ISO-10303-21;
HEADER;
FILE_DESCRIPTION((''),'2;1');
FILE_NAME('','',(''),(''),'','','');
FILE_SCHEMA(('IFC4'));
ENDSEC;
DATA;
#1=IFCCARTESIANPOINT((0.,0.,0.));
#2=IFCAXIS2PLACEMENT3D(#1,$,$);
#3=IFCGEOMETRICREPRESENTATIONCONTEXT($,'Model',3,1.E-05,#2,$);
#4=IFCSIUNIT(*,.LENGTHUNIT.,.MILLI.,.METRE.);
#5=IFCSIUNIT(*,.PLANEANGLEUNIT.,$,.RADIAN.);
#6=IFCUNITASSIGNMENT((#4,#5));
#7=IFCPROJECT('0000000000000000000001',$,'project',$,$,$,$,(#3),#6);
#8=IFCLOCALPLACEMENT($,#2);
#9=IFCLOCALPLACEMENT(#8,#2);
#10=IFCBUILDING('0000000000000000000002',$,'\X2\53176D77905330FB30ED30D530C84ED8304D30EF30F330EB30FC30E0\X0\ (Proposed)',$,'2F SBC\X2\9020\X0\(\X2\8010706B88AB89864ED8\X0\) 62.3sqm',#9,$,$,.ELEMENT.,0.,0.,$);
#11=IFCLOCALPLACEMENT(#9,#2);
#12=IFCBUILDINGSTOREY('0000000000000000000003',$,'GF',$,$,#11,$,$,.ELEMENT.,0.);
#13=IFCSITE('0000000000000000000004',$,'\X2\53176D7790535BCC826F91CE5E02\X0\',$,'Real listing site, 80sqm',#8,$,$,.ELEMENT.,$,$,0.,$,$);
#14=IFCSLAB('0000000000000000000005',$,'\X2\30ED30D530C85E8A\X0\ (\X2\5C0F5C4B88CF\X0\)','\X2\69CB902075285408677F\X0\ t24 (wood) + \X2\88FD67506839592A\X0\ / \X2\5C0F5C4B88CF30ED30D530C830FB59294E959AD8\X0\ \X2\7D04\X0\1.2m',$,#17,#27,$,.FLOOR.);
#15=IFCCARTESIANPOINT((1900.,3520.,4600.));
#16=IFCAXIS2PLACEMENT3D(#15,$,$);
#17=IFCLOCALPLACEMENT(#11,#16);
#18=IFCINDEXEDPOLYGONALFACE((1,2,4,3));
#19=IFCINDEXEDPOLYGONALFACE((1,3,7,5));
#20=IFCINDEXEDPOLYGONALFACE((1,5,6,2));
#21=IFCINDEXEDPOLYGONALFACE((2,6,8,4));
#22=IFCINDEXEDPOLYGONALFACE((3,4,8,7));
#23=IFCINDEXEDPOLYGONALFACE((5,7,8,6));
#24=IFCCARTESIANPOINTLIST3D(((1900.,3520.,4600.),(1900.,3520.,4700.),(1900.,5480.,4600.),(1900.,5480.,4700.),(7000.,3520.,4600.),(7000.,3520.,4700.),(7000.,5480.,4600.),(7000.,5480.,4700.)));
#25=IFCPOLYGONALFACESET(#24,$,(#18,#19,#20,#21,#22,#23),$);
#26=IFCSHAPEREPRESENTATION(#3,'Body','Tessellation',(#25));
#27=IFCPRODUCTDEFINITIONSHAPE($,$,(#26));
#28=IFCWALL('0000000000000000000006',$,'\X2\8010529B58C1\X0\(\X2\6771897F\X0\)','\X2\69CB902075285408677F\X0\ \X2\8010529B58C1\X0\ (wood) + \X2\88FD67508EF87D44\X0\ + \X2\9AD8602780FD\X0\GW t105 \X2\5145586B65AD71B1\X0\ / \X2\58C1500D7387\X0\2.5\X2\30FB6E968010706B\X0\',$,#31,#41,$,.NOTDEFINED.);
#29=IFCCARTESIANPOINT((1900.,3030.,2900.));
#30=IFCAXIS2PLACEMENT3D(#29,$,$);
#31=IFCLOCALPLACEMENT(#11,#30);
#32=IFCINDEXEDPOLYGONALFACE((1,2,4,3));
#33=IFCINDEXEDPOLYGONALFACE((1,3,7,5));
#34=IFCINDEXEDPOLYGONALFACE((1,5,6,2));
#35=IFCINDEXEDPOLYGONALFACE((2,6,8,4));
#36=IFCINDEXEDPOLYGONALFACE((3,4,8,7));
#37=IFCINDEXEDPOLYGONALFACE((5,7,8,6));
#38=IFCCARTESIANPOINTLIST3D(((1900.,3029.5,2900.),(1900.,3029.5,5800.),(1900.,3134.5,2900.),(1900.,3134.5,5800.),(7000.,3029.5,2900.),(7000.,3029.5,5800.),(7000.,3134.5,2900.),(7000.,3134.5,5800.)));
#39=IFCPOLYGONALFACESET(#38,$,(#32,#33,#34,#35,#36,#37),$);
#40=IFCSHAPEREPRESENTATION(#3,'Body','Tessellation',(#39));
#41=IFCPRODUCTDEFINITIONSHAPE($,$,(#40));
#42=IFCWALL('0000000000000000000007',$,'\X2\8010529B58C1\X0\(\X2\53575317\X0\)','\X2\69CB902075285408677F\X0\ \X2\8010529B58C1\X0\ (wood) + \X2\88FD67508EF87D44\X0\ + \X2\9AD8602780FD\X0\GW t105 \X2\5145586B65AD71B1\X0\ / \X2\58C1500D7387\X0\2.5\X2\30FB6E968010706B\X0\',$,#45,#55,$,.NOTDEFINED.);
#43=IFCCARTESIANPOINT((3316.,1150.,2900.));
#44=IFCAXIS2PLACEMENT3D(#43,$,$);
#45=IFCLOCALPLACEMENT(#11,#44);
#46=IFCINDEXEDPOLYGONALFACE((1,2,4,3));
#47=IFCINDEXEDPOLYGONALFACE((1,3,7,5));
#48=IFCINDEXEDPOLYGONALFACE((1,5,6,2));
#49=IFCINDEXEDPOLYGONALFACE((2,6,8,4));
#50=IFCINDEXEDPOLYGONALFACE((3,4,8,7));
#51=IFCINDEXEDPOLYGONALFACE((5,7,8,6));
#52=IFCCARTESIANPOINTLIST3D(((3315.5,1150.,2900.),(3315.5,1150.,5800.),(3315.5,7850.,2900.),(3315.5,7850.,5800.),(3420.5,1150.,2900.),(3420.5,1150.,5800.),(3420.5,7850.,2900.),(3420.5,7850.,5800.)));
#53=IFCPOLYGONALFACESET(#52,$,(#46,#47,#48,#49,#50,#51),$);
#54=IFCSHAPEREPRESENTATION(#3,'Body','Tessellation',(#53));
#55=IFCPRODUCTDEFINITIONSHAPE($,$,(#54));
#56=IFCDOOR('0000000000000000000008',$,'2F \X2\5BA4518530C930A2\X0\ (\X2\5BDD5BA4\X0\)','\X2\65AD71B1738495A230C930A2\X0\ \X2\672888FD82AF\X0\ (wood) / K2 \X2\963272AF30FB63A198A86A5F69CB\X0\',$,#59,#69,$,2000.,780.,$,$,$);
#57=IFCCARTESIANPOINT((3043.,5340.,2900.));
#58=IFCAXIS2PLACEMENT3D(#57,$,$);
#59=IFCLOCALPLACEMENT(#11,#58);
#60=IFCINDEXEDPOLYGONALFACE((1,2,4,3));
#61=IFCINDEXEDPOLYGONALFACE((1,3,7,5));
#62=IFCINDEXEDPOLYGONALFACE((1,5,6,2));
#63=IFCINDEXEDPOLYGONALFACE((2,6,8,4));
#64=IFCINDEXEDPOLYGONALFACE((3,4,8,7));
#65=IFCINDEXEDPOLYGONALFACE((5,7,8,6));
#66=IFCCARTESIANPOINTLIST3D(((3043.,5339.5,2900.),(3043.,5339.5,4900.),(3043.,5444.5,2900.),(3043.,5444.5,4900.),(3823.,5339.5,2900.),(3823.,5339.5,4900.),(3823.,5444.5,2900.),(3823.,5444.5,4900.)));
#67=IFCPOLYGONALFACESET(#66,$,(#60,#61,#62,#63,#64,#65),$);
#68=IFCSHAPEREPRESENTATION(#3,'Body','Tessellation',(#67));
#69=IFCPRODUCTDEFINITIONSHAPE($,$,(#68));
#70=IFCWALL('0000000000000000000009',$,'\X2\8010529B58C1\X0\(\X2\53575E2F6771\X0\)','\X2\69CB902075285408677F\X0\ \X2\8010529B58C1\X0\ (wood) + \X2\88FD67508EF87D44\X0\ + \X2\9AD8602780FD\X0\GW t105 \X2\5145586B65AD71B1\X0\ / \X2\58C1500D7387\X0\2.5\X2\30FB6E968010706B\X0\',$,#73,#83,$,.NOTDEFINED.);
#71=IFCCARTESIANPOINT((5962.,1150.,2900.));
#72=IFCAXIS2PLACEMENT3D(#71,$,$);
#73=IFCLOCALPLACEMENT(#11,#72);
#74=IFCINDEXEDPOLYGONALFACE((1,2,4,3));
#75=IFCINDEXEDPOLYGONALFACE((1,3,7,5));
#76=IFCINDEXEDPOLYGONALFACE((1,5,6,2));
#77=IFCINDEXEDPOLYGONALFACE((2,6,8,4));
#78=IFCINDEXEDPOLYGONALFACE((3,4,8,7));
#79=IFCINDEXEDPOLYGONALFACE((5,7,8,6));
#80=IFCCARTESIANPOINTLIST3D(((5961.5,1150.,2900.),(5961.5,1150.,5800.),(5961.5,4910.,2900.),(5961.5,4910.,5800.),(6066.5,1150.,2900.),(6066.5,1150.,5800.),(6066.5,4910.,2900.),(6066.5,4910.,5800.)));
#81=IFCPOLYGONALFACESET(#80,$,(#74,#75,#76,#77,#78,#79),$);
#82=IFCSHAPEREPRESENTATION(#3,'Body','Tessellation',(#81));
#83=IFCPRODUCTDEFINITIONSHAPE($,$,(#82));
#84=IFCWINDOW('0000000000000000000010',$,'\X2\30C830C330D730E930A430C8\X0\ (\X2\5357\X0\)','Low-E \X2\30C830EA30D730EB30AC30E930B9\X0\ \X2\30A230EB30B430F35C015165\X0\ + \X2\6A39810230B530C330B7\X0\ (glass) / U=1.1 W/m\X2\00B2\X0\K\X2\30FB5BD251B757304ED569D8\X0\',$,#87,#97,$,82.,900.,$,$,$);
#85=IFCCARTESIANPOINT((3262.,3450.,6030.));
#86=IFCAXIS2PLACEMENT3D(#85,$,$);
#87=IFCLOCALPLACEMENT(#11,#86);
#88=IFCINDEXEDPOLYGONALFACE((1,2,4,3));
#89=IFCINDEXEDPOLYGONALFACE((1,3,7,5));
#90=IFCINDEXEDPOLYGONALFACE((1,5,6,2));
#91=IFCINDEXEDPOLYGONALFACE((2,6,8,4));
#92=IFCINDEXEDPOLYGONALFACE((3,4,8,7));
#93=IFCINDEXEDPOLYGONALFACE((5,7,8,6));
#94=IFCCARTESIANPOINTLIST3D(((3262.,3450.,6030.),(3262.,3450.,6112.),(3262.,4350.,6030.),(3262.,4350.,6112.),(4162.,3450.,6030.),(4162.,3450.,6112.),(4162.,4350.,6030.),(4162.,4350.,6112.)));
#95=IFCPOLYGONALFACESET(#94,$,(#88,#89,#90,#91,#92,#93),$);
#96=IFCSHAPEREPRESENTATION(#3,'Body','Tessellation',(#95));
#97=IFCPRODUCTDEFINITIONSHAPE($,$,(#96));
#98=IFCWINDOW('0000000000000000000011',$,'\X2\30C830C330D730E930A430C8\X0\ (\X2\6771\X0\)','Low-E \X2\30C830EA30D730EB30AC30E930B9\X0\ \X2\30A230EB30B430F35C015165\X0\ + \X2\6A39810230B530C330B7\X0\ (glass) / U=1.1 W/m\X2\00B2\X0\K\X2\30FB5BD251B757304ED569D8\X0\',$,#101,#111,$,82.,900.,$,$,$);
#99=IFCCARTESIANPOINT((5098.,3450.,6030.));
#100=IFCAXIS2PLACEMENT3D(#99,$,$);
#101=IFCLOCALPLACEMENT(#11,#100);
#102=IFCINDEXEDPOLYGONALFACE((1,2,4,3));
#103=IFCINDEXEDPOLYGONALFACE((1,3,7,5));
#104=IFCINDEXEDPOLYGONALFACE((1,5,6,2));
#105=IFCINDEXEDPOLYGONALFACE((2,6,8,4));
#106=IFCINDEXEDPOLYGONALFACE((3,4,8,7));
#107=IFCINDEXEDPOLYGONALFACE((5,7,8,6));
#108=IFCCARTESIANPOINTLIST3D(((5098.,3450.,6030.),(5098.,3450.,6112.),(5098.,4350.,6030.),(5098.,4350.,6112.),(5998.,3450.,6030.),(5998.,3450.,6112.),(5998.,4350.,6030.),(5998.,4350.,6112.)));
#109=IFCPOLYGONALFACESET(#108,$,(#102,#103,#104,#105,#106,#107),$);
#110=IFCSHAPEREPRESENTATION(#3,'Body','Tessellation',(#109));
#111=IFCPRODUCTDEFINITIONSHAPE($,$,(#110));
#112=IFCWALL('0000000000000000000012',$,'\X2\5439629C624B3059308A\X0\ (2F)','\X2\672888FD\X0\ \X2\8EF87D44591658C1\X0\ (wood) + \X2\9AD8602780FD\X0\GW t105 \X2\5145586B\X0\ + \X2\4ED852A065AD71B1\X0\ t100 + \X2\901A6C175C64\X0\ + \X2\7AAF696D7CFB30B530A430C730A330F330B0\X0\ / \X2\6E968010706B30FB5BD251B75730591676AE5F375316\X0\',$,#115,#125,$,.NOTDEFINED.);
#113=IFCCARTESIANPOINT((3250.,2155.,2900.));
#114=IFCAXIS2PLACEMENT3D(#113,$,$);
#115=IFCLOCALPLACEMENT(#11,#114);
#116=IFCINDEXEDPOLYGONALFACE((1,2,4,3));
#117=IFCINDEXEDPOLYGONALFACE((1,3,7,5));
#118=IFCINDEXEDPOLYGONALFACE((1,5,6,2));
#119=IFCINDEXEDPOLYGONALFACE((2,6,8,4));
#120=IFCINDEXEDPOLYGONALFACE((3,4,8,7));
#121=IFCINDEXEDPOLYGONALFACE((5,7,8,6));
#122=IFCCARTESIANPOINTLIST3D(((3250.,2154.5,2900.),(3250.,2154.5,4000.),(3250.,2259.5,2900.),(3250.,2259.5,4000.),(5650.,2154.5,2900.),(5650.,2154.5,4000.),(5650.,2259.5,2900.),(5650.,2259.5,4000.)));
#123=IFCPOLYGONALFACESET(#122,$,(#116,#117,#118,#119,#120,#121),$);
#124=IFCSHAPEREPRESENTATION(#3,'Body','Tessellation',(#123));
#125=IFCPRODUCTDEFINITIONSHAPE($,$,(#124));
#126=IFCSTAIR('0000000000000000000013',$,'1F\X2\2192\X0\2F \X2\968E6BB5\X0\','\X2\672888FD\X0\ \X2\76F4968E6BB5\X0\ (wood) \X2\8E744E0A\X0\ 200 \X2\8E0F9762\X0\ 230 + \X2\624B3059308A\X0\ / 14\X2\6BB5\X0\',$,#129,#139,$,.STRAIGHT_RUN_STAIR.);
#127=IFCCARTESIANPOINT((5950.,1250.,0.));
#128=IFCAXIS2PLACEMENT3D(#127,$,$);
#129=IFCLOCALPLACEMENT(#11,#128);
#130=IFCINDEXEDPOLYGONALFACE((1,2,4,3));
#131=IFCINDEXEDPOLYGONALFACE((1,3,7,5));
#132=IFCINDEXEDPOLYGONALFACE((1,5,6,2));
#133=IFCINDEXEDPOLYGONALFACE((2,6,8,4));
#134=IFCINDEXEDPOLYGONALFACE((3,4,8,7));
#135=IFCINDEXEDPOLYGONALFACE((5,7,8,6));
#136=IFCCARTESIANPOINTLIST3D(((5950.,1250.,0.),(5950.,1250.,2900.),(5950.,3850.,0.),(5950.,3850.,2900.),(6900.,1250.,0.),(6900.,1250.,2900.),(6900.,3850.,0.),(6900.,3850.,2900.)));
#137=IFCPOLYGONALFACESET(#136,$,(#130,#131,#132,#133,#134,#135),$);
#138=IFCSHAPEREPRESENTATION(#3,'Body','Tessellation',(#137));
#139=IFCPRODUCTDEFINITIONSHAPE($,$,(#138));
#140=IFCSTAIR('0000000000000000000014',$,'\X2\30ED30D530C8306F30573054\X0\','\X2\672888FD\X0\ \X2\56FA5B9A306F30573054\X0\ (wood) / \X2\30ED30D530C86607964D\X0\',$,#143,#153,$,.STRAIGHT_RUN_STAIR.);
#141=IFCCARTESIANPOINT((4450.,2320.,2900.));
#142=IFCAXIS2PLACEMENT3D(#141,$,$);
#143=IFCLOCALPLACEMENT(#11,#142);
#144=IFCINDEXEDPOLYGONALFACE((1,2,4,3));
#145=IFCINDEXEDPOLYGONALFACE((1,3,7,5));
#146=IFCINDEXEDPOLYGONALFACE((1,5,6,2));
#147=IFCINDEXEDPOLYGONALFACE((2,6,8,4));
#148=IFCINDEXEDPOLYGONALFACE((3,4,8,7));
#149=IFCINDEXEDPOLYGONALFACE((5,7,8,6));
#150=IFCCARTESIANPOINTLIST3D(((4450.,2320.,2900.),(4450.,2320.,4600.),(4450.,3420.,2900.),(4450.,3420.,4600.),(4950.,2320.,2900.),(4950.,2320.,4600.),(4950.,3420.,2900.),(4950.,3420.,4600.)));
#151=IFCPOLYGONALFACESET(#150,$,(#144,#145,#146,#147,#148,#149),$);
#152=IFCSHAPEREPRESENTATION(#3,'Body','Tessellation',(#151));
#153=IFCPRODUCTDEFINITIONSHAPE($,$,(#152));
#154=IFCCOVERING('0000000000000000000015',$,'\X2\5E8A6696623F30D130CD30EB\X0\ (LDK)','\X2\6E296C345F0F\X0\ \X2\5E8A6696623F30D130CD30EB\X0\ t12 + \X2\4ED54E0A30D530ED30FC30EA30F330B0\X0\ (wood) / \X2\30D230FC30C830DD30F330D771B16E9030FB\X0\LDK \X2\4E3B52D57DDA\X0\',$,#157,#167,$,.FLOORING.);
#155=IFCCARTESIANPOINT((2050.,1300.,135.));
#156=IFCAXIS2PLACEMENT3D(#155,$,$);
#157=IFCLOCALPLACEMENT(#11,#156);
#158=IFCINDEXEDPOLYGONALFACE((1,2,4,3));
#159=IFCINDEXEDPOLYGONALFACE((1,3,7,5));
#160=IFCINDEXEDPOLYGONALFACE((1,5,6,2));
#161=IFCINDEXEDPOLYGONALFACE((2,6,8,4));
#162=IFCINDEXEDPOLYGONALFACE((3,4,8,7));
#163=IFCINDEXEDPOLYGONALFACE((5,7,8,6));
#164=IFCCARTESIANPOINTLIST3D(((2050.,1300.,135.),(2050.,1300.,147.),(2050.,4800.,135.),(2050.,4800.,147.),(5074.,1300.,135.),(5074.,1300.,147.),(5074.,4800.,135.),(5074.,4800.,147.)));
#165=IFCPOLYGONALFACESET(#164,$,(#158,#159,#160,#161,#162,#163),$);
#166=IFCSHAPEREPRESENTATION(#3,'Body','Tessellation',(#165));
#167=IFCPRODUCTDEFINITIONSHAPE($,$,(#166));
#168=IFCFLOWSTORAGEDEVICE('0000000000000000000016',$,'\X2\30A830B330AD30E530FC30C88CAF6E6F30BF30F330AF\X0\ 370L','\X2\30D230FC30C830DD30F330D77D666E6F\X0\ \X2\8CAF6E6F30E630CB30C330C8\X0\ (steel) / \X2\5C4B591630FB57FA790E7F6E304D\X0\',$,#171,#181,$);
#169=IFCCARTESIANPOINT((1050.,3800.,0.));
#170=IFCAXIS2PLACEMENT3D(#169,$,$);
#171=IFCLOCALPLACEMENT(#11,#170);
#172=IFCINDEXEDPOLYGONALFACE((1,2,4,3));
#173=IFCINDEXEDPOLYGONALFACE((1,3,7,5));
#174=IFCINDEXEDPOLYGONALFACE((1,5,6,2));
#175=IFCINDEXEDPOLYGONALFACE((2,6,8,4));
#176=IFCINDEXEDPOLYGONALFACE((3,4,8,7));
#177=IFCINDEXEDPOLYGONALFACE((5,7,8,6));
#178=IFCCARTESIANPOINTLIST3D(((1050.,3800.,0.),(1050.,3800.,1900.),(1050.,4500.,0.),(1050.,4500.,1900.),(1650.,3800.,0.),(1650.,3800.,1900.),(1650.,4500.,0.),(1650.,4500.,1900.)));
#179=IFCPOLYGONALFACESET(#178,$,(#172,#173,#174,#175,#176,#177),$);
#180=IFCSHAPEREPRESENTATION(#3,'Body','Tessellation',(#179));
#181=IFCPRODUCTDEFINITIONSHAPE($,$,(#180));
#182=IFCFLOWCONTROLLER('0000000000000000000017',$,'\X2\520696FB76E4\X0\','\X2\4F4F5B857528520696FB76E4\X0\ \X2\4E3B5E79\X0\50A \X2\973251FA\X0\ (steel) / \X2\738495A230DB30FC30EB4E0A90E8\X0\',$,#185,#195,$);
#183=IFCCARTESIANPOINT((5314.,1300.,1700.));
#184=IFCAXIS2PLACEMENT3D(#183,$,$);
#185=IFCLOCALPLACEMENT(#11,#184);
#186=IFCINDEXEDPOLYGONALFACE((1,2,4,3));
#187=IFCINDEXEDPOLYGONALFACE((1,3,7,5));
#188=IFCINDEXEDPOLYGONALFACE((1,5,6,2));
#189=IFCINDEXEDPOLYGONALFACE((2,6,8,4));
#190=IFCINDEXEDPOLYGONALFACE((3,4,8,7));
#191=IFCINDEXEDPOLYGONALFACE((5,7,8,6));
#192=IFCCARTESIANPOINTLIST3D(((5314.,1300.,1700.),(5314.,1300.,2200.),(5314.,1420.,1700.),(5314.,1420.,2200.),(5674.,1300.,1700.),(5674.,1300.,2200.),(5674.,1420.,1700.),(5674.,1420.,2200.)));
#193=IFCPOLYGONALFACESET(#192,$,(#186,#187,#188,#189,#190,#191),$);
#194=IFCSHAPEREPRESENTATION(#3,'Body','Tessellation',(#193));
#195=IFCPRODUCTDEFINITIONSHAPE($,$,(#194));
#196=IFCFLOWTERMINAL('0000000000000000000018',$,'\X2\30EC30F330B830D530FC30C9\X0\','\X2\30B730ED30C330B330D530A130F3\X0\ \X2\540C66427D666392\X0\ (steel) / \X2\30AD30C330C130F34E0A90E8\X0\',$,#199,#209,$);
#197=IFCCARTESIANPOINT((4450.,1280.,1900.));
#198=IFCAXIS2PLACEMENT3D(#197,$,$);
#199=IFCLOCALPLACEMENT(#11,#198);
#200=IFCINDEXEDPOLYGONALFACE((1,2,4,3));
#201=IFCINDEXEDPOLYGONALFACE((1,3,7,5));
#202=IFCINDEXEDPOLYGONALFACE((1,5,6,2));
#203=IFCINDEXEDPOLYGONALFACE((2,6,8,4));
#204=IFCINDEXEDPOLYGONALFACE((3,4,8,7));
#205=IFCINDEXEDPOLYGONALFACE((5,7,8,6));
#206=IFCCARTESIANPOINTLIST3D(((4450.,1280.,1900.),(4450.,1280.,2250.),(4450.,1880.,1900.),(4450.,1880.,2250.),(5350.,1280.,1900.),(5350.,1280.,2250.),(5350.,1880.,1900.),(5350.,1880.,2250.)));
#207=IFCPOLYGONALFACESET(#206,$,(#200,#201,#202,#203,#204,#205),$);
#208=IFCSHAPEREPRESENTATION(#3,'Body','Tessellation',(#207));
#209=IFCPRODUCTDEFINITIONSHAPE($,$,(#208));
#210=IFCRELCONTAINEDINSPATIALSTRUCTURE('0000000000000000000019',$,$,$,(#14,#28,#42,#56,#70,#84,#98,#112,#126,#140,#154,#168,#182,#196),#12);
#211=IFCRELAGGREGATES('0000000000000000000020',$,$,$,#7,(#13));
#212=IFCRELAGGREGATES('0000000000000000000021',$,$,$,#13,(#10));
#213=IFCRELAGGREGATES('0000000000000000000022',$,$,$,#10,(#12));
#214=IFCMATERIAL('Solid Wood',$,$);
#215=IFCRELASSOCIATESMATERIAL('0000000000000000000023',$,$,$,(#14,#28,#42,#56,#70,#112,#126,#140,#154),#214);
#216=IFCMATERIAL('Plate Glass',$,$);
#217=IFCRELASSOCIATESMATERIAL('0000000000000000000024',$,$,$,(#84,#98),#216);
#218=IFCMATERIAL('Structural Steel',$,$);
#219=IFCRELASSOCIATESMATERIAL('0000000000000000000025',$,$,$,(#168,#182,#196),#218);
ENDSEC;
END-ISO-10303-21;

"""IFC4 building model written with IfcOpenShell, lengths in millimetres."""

from ifc_helpers import new_model, si_unit, frame, frame_2d, origin, place, context, project, spatial, rectangle, extrude, material, element, fill, save


model = new_model("IFC4")

# Units and contexts
model_context = context("Model", 3, precision=1e-05, world=origin())
ifc_project = project(units=[si_unit("LENGTHUNIT", "METRE", prefix="MILLI"), si_unit("PLANEANGLEUNIT", "RADIAN")], contexts=[model_context])

# Site, building, storey
site_placement = place(None, origin())
site = spatial("IfcSite", under=ifc_project, at=site_placement, Name="北海道富良野市", ObjectType="Real listing site, 80sqm", CompositionType="ELEMENT", RefElevation=0.0)
building_placement = place(site_placement, origin())
building = spatial("IfcBuilding", under=site, at=building_placement, Name="北海道・ロフト付きワンルーム (Proposed)", ObjectType="2F SBC造(耐火被覆付) 62.3sqm", CompositionType="ELEMENT", ElevationOfRefHeight=0.0, ElevationOfTerrain=0.0)
storey_placement = place(building_placement, origin())
storey = spatial("IfcBuildingStorey", under=building, at=storey_placement, Name="GF", CompositionType="ELEMENT", Elevation=0.0)

# Shared definitions
ifc_material_1 = material(Name="Solid Wood")

# Slab
slab_placement = place(storey_placement, frame((1900.0, 3520.0, 4600.0)))
element("IfcSlab", 1, at=slab_placement, inside=storey, material=ifc_material_1, Name="ロフト床 (小屋裏)", Description="構造用合板 t24 (wood) + 製材根太 / 小屋裏ロフト・天井高 約1.2m", PredefinedType="FLOOR", context=model_context, shape_type="SweptSolid", body=[
    extrude(rectangle(XDim=5100.0, YDim=1960.0, at=frame_2d((2550.0, 980.0))), frame((1900.0, 3520.0, 4600.0)), (0.0, 0.0, 1.0), 100.0),
])

# Wall
wall_1_placement = place(storey_placement, frame((1900.0, 3030.0, 2900.0)))
element("IfcWall", 2, at=wall_1_placement, inside=storey, material=ifc_material_1, Name="耐力壁(東西)", Description="構造用合板 耐力壁 (wood) + 製材軸組 + 高性能GW t105 充填断熱 / 壁倍率2.5・準耐火", PredefinedType="NOTDEFINED", context=model_context, shape_type="SweptSolid", body=[
    extrude(rectangle(XDim=5100.0, YDim=105.0, at=frame_2d((2550.0, 52.0))), frame((1900.0, 3030.0, 2900.0)), (0.0, 0.0, 1.0), 2900.0),
])

# Wall, opening, door
wall_2_placement = place(storey_placement, frame((3316.0, 1150.0, 2900.0)))
wall_2 = element("IfcWall", 3, at=wall_2_placement, inside=storey, material=ifc_material_1, Name="耐力壁(南北)", Description="構造用合板 耐力壁 (wood) + 製材軸組 + 高性能GW t105 充填断熱 / 壁倍率2.5・準耐火", PredefinedType="NOTDEFINED", context=model_context, shape_type="SweptSolid", body=[
    extrude(rectangle(XDim=105.0, YDim=6700.0, at=frame_2d((52.0, 3350.0))), frame((3316.0, 1150.0, 2900.0)), (0.0, 0.0, 1.0), 2900.0),
])
opening_placement = place(storey_placement, frame((3043.0, 5340.0, 2900.0)))
opening = element("IfcOpeningElement", 4, at=opening_placement, cuts=wall_2, PredefinedType="NOTDEFINED", context=model_context, shape_type="SweptSolid", body=[
    extrude(rectangle(XDim=780.0, YDim=105.0, at=frame_2d((390.0, 52.0))), frame((3043.0, 5340.0, 2900.0)), (0.0, 0.0, 1.0), 2000.0),
])
door_placement = place(storey_placement, frame((3043.0, 5340.0, 2900.0)))
door = element("IfcDoor", 5, at=door_placement, inside=storey, material=ifc_material_1, Name="2F 室内ドア (寝室)", Description="断熱玄関ドア 木製芯 (wood) / K2 防犯・採風機構", OverallHeight=2000.0, OverallWidth=780.0, context=model_context, shape_type="SweptSolid", body=[
    extrude(rectangle(XDim=780.0, YDim=105.0, at=frame_2d((390.0, 52.0))), frame((3043.0, 5340.0, 2900.0)), (0.0, 0.0, 1.0), 2000.0),
])
fill(opening, door)

# Wall
wall_3_placement = place(storey_placement, frame((5962.0, 1150.0, 2900.0)))
element("IfcWall", 6, at=wall_3_placement, inside=storey, material=ifc_material_1, Name="耐力壁(南帯東)", Description="構造用合板 耐力壁 (wood) + 製材軸組 + 高性能GW t105 充填断熱 / 壁倍率2.5・準耐火", PredefinedType="NOTDEFINED", context=model_context, shape_type="SweptSolid", body=[
    extrude(rectangle(XDim=105.0, YDim=3760.0, at=frame_2d((52.0, 1880.0))), frame((5962.0, 1150.0, 2900.0)), (0.0, 0.0, 1.0), 2900.0),
])

# Windows
ifc_material_2 = material(Name="Plate Glass")
window_1_placement = place(storey_placement, frame((3262.0, 3450.0, 6030.0)))
element("IfcWindow", 7, at=window_1_placement, inside=storey, material=ifc_material_2, Name="トップライト (南)", Description="Low-E トリプルガラス アルゴン封入 + 樹脂サッシ (glass) / U=1.1 W/m²K・寒冷地仕様", OverallHeight=82.0, OverallWidth=900.0, context=model_context, shape_type="SweptSolid", body=[
    extrude(rectangle(XDim=900.0, YDim=900.0, at=frame_2d((450.0, 450.0))), frame((3262.0, 3450.0, 6030.0)), (0.0, 0.0, 1.0), 82.0),
])
window_2_placement = place(storey_placement, frame((5098.0, 3450.0, 6030.0)))
element("IfcWindow", 8, at=window_2_placement, inside=storey, material=ifc_material_2, Name="トップライト (東)", Description="Low-E トリプルガラス アルゴン封入 + 樹脂サッシ (glass) / U=1.1 W/m²K・寒冷地仕様", OverallHeight=82.0, OverallWidth=900.0, context=model_context, shape_type="SweptSolid", body=[
    extrude(rectangle(XDim=900.0, YDim=900.0, at=frame_2d((450.0, 450.0))), frame((5098.0, 3450.0, 6030.0)), (0.0, 0.0, 1.0), 82.0),
])

# Wall
wall_4_placement = place(storey_placement, frame((3250.0, 2155.0, 2900.0)))
element("IfcWall", 9, at=wall_4_placement, inside=storey, material=ifc_material_1, Name="吹抜手すり (2F)", Description="木製 軸組外壁 (wood) + 高性能GW t105 充填 + 付加断熱 t100 + 通気層 + 窯業系サイディング / 準耐火・寒冷地外皮強化", PredefinedType="NOTDEFINED", context=model_context, shape_type="SweptSolid", body=[
    extrude(rectangle(XDim=2400.0, YDim=105.0, at=frame_2d((1200.0, 52.0))), frame((3250.0, 2155.0, 2900.0)), (0.0, 0.0, 1.0), 1100.0),
])

# Stairs
stair_1_placement = place(storey_placement, frame((5950.0, 1250.0, 0.0)))
element("IfcStair", 10, at=stair_1_placement, inside=storey, material=ifc_material_1, Name="1F→2F 階段", Description="木製 直階段 (wood) 蹴上 200 踏面 230 + 手すり / 14段", PredefinedType="STRAIGHT_RUN_STAIR", context=model_context, shape_type="SweptSolid", body=[
    extrude(rectangle(XDim=950.0, YDim=2600.0, at=frame_2d((475.0, 1300.0))), frame((5950.0, 1250.0, 0.0)), (0.0, 0.0, 1.0), 2900.0),
])
stair_2_placement = place(storey_placement, frame((4450.0, 2320.0, 2900.0)))
element("IfcStair", 11, at=stair_2_placement, inside=storey, material=ifc_material_1, Name="ロフトはしご", Description="木製 固定はしご (wood) / ロフト昇降", PredefinedType="STRAIGHT_RUN_STAIR", context=model_context, shape_type="SweptSolid", body=[
    extrude(rectangle(XDim=500.0, YDim=1100.0, at=frame_2d((250.0, 550.0))), frame((4450.0, 2320.0, 2900.0)), (0.0, 0.0, 1.0), 1700.0),
])

# Covering
covering_placement = place(storey_placement, frame((2050.0, 1300.0, 135.0)))
element("IfcCovering", 12, at=covering_placement, inside=storey, material=ifc_material_1, Name="床暖房パネル (LDK)", Description="温水式 床暖房パネル t12 + 仕上フローリング (wood) / ヒートポンプ熱源・LDK 主動線", PredefinedType="FLOORING", context=model_context, shape_type="SweptSolid", body=[
    extrude(rectangle(XDim=3024.0, YDim=3500.0, at=frame_2d((1512.0, 1750.0))), frame((2050.0, 1300.0, 135.0)), (0.0, 0.0, 1.0), 12.0),
])

# Flow storage device
ifc_material_3 = material(Name="Structural Steel")
flow_storage_device_placement = place(storey_placement, frame((1050.0, 3800.0, 0.0)))
element("IfcFlowStorageDevice", 13, at=flow_storage_device_placement, inside=storey, material=ifc_material_3, Name="エコキュート貯湯タンク 370L", Description="ヒートポンプ給湯 貯湯ユニット (steel) / 屋外・基礎置き", context=model_context, shape_type="SweptSolid", body=[
    extrude(rectangle(XDim=600.0, YDim=700.0, at=frame_2d((300.0, 350.0))), frame((1050.0, 3800.0, 0.0)), (0.0, 0.0, 1.0), 1900.0),
])

# Flow controller
flow_controller_placement = place(storey_placement, frame((5314.0, 1300.0, 1700.0)))
element("IfcFlowController", 14, at=flow_controller_placement, inside=storey, material=ifc_material_3, Name="分電盤", Description="住宅用分電盤 主幹50A 露出 (steel) / 玄関ホール上部", context=model_context, shape_type="SweptSolid", body=[
    extrude(rectangle(XDim=360.0, YDim=120.0, at=frame_2d((180.0, 60.0))), frame((5314.0, 1300.0, 1700.0)), (0.0, 0.0, 1.0), 500.0),
])

# Flow terminal
flow_terminal_1_placement = place(storey_placement, frame((4450.0, 1280.0, 1900.0)))
element("IfcFlowTerminal", 15, at=flow_terminal_1_placement, inside=storey, material=ifc_material_3, Name="レンジフード", Description="シロッコファン 同時給排 (steel) / キッチン上部", context=model_context, shape_type="SweptSolid", body=[
    extrude(rectangle(XDim=900.0, YDim=600.0, at=frame_2d((450.0, 300.0))), frame((4450.0, 1280.0, 1900.0)), (0.0, 0.0, 1.0), 350.0),
])

save(model, "model.ifc")
